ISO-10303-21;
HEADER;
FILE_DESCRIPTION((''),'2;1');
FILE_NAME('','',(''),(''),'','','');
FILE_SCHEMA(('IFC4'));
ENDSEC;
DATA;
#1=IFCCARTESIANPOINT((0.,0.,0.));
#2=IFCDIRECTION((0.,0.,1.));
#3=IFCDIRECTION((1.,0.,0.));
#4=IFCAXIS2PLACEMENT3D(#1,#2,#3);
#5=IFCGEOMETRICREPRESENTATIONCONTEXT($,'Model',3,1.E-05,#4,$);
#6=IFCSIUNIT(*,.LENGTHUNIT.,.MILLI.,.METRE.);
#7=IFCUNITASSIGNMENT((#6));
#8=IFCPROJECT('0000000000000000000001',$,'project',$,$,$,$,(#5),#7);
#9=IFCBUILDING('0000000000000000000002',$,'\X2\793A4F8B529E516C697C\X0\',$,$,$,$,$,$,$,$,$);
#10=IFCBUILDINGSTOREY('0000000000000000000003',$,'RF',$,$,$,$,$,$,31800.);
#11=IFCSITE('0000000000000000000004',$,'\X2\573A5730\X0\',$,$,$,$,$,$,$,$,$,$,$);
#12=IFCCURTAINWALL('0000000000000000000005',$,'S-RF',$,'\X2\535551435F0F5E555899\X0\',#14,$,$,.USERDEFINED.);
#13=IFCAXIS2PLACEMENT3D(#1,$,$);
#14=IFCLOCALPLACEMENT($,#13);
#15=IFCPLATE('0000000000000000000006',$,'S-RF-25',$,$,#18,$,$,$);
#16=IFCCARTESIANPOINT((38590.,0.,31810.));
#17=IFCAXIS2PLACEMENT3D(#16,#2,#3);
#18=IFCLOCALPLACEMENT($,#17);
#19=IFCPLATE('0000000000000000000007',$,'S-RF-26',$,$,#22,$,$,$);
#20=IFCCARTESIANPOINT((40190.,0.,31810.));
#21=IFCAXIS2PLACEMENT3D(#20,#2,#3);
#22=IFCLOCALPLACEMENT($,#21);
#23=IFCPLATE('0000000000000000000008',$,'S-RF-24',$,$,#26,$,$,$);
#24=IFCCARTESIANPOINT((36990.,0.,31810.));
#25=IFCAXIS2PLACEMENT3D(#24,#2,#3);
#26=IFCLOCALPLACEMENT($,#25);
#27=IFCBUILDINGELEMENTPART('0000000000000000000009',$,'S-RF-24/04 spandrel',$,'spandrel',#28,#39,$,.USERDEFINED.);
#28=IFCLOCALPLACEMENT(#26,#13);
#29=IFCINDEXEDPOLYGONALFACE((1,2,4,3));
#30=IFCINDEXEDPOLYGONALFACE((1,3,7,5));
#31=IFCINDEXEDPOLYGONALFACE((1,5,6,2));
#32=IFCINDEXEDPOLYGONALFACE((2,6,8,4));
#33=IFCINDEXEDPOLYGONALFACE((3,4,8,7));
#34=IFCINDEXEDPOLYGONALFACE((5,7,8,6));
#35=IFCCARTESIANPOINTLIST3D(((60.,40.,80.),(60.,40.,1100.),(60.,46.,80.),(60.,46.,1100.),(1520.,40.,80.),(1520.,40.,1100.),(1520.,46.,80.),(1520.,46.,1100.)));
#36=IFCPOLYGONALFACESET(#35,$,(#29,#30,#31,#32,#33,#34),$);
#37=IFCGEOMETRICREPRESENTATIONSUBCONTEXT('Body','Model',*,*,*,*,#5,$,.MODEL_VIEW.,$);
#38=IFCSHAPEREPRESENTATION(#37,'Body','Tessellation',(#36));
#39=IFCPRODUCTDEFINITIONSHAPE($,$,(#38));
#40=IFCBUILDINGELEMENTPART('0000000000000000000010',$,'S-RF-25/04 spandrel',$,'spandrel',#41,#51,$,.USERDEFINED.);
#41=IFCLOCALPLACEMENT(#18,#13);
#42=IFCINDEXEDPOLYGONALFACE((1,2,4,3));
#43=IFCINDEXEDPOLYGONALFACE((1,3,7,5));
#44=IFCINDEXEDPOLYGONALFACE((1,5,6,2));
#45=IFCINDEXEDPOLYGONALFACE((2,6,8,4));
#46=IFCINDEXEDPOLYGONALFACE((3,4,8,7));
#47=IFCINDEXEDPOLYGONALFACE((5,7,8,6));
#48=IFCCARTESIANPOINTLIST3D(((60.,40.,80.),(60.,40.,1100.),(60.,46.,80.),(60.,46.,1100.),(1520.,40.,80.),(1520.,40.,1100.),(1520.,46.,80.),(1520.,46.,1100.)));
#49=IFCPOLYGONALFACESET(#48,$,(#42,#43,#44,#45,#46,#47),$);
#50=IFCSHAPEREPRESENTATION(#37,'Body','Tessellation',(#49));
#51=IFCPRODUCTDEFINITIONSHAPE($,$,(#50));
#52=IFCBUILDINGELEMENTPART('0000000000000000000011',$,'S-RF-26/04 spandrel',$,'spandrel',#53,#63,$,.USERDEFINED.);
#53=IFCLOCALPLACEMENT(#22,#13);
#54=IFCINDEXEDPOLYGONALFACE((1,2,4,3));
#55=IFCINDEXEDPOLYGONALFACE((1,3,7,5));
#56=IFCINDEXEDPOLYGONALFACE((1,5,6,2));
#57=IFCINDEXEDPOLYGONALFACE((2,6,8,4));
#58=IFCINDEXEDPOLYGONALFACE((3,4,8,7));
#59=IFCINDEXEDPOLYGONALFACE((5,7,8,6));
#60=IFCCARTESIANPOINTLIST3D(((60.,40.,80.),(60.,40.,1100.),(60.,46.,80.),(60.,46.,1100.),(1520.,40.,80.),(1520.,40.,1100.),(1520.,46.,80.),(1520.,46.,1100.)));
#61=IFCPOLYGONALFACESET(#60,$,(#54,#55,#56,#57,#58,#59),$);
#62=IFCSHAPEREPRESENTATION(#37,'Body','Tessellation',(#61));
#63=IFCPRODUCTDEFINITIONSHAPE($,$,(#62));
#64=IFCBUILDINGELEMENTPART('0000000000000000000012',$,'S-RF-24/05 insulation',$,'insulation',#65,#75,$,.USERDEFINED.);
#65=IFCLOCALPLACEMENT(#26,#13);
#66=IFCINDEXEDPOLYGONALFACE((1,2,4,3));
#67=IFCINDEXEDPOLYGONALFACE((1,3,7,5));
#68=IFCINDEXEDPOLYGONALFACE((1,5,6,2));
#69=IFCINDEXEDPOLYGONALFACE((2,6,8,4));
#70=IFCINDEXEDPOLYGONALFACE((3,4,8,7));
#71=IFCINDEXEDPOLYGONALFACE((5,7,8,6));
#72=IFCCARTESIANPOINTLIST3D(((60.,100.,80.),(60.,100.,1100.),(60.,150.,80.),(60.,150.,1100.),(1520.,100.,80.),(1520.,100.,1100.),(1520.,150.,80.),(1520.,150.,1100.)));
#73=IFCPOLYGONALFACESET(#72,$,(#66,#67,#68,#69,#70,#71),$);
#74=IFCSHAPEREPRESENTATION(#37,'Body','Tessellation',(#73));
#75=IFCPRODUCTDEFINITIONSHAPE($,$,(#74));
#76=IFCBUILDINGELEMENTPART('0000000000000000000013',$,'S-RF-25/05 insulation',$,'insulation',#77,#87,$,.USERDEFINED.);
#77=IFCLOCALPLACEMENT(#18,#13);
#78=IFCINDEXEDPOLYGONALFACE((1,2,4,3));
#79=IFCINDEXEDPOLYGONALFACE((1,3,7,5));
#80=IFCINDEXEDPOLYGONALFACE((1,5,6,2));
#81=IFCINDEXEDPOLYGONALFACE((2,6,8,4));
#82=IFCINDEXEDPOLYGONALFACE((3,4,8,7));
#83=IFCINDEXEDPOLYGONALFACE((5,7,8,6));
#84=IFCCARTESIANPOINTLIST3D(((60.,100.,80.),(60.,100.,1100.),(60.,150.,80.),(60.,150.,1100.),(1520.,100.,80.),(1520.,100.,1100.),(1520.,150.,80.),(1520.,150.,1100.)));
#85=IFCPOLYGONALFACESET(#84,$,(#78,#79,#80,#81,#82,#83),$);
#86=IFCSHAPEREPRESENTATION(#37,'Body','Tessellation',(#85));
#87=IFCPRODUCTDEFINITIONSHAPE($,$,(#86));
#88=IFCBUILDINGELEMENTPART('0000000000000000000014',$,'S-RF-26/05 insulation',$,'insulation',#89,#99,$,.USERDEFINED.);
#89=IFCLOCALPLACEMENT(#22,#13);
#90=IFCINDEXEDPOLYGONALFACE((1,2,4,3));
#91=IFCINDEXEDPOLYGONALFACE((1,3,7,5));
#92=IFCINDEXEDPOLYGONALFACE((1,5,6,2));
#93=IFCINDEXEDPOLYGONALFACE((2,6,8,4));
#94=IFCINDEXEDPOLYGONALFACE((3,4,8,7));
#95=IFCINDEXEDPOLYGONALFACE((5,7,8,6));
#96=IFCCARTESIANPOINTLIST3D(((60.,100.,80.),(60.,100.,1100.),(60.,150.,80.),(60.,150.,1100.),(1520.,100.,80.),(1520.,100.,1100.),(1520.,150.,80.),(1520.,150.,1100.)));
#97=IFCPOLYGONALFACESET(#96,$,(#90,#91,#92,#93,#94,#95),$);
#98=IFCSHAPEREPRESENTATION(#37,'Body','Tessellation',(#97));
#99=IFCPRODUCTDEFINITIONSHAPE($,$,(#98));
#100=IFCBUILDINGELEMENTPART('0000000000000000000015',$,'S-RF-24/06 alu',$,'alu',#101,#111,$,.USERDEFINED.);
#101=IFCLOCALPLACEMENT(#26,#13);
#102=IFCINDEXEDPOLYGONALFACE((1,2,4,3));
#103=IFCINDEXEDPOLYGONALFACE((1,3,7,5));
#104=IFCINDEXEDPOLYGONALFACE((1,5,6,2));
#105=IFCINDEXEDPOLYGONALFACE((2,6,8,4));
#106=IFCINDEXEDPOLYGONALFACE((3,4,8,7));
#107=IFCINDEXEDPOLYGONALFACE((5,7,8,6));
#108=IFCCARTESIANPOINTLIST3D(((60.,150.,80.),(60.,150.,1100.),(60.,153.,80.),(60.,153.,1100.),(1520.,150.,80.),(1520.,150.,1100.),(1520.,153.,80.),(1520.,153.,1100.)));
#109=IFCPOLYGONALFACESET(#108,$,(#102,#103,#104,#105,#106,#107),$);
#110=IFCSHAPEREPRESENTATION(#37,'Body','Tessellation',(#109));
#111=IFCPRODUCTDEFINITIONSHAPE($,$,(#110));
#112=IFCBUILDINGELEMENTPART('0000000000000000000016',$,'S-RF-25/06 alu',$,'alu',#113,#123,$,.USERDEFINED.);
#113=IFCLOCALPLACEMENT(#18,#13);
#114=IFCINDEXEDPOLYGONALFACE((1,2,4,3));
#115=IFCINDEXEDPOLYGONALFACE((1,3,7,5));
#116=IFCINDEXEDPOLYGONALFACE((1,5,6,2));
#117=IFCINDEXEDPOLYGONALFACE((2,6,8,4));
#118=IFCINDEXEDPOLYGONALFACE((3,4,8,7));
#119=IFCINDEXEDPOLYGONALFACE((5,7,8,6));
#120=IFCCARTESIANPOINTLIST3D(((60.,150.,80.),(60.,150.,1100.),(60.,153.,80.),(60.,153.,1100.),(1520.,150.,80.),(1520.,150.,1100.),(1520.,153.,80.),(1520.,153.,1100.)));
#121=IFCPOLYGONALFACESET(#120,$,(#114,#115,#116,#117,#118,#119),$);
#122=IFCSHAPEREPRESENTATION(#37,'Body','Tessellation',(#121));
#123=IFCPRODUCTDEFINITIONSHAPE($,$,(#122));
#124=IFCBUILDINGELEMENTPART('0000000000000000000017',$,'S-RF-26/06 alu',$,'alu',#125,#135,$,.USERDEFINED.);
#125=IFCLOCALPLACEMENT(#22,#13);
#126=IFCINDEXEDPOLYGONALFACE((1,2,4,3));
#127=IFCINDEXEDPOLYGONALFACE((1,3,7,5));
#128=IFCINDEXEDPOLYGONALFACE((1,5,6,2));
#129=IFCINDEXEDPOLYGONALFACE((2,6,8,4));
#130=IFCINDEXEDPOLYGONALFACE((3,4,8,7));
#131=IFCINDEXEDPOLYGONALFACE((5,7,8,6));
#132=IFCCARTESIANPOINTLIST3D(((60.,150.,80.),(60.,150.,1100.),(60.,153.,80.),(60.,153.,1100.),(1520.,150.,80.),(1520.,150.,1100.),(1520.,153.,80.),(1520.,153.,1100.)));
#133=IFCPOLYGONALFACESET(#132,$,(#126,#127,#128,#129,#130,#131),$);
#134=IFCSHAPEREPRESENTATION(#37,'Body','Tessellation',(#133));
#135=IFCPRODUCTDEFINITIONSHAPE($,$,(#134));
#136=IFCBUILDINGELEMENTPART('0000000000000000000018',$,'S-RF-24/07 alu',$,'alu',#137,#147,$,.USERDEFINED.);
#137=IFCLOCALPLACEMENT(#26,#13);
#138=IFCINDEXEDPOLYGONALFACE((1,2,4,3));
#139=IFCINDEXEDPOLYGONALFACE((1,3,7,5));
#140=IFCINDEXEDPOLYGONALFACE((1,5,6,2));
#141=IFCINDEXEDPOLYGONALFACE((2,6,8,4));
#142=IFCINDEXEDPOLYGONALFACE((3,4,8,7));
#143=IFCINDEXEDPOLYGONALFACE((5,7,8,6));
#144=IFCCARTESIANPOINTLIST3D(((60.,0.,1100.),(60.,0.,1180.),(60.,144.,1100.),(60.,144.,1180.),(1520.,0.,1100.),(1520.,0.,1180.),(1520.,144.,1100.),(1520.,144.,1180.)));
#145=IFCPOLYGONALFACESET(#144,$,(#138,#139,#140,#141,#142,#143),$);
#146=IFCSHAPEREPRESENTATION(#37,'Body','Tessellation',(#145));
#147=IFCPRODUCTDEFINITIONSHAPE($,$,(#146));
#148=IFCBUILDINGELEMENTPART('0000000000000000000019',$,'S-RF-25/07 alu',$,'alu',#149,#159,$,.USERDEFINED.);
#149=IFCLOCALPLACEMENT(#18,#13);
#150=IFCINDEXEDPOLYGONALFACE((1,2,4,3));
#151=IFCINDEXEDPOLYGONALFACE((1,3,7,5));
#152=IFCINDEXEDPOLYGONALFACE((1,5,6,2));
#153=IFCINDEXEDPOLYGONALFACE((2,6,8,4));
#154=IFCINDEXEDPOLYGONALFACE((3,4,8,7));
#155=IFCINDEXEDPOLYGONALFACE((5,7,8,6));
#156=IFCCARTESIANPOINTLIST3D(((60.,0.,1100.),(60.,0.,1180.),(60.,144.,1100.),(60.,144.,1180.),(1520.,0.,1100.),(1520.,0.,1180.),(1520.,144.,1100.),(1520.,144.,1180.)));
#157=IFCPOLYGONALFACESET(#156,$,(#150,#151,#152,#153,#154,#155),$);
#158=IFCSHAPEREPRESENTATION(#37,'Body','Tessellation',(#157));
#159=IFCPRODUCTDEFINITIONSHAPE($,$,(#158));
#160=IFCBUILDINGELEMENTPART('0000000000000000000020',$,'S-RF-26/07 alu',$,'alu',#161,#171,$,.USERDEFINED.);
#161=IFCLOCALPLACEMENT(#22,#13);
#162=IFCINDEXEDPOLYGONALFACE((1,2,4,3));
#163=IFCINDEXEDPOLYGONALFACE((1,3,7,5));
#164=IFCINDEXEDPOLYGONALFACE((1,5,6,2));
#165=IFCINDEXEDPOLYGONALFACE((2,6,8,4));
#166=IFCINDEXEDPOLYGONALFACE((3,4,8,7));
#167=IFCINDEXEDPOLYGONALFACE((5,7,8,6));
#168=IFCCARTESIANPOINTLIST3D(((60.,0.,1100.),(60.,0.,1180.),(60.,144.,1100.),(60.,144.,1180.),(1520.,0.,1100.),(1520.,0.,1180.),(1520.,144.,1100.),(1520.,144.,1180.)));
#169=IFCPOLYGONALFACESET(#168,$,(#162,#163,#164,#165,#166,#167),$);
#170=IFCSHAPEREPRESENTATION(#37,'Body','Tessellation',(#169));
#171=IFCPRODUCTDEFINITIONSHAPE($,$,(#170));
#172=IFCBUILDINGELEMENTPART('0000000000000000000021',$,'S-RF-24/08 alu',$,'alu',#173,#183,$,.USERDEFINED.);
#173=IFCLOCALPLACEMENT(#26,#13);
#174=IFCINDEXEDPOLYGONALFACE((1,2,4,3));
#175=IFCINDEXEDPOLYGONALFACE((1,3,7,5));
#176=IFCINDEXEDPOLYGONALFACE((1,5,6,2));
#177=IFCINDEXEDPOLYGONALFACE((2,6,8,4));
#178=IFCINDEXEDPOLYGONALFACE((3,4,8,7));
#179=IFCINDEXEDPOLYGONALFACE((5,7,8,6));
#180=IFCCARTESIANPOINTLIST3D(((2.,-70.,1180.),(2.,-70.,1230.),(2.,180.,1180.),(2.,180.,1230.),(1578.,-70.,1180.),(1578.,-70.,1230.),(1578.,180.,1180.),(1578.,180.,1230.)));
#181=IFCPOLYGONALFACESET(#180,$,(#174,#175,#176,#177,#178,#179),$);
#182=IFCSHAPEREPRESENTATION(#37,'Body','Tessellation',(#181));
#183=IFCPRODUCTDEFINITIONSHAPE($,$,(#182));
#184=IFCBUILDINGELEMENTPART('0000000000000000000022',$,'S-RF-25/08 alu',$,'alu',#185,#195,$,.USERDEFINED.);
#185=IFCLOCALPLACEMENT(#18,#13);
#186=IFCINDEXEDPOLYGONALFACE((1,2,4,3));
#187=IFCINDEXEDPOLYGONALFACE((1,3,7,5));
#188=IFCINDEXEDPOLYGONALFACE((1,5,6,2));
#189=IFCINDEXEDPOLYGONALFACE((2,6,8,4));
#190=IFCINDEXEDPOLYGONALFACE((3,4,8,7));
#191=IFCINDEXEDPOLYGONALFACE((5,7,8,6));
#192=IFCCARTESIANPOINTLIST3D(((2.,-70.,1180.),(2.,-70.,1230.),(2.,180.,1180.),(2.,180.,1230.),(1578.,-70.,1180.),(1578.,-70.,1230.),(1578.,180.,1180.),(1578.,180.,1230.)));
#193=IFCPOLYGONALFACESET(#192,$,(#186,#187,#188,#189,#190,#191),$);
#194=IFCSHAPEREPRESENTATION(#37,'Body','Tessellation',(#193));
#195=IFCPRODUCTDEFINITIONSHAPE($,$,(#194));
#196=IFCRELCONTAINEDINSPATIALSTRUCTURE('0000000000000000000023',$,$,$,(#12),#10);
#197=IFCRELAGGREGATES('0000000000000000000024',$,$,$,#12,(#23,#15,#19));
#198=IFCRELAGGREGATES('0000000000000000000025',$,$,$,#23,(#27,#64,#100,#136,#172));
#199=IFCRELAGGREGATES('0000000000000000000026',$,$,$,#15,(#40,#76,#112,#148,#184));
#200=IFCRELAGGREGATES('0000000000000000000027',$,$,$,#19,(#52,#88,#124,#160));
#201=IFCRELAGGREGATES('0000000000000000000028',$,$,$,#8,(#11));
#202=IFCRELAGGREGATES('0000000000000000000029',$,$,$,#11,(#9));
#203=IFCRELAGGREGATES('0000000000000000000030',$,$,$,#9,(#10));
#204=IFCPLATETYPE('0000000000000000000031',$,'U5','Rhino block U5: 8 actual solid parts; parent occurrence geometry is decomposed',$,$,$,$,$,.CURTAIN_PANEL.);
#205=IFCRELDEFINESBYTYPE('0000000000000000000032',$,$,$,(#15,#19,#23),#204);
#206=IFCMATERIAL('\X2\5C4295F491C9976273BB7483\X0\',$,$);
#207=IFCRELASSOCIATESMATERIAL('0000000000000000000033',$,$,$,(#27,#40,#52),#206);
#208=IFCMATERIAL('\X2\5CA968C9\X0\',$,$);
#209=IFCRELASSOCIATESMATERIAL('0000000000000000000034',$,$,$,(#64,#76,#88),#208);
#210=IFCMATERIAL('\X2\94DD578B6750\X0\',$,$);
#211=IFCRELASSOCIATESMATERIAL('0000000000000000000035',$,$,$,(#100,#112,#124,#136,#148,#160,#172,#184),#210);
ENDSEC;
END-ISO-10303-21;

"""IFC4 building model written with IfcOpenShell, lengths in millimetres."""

from ifc_helpers import new_model, si_unit, frame, frame_2d, origin, origin_with_axes, place, context, subcontext, project, spatial, rectangle, extrude, source, transform, mapped, material, type_object, element, aggregate, save


model = new_model("IFC4")

# Units and contexts
model_context = context("Model", 3, precision=1e-05, world=origin_with_axes())
body_context = subcontext(model_context, "Body", "Model", "MODEL_VIEW")
ifc_project = project(units=[si_unit("LENGTHUNIT", "METRE", prefix="MILLI")], contexts=[model_context])

# Site, building, storey
site = spatial("IfcSite", under=ifc_project, Name="场地")
building = spatial("IfcBuilding", under=site, Name="示例办公楼")
storey = spatial("IfcBuildingStorey", under=building, Name="RF", Elevation=31800.0)

# Curtain wall, plates, building element parts
curtain_wall = element("IfcCurtainWall", 1, inside=storey, Name="S-RF", ObjectType="单元式幕墙", PredefinedType="USERDEFINED")
plate_type = type_object("IfcPlateType", Name="U5", Description="Rhino block U5: 8 actual solid parts; parent occurrence geometry is decomposed", PredefinedType="CURTAIN_PANEL")
plate_1_placement = place(None, frame((38590.0, 0.0, 31810.0), z_axis=(0.0, 0.0, 1.0), x_axis=(1.0, 0.0, 0.0)))
plate_1 = element("IfcPlate", 2, at=plate_1_placement, type_object=plate_type, Name="S-RF-25")
ifc_material_1 = material(Name="铝型材")
plate_2_placement = place(None, frame((40190.0, 0.0, 31810.0), z_axis=(0.0, 0.0, 1.0), x_axis=(1.0, 0.0, 0.0)))
plate_2 = element("IfcPlate", 3, at=plate_2_placement, type_object=plate_type, Name="S-RF-26")
plate_3_placement = place(None, frame((36990.0, 0.0, 31810.0), z_axis=(0.0, 0.0, 1.0), x_axis=(1.0, 0.0, 0.0)))
plate_3 = element("IfcPlate", 4, at=plate_3_placement, type_object=plate_type, Name="S-RF-24")
aggregate(curtain_wall, [plate_3, plate_1, plate_2])
ifc_material_2 = material(Name="层间釉面玻璃")
shared_shape_1 = source(origin(), body_context, "Body", "SweptSolid", [
    extrude(rectangle(XDim=1460.0, YDim=6.0, at=frame_2d((790.0, 43.0))), frame((0.0, 0.0, 80.0)), (0.0, 0.0, 1.0), 1020.0),
])
building_element_part_1_placement = place(plate_3_placement, origin())
building_element_part_1 = element("IfcBuildingElementPart", 5, at=building_element_part_1_placement, material=ifc_material_2, Name="S-RF-24/04 spandrel", ObjectType="spandrel", PredefinedType="USERDEFINED", context=body_context, shape_type="MappedRepresentation", body=[
    mapped(shared_shape_1, transform((0.0, 0.0, 0.0))),
])
building_element_part_2_placement = place(plate_1_placement, origin())
building_element_part_2 = element("IfcBuildingElementPart", 6, at=building_element_part_2_placement, material=ifc_material_2, Name="S-RF-25/04 spandrel", ObjectType="spandrel", PredefinedType="USERDEFINED", context=body_context, shape_type="MappedRepresentation", body=[
    mapped(shared_shape_1, transform((0.0, 0.0, 0.0))),
])
building_element_part_3_placement = place(plate_2_placement, origin())
building_element_part_3 = element("IfcBuildingElementPart", 7, at=building_element_part_3_placement, material=ifc_material_2, Name="S-RF-26/04 spandrel", ObjectType="spandrel", PredefinedType="USERDEFINED", context=body_context, shape_type="MappedRepresentation", body=[
    mapped(shared_shape_1, transform((0.0, 0.0, 0.0))),
])
ifc_material_3 = material(Name="岩棉")
shared_shape_2 = source(origin(), body_context, "Body", "SweptSolid", [
    extrude(rectangle(XDim=1460.0, YDim=50.0, at=frame_2d((790.0, 125.0))), frame((0.0, 0.0, 80.0)), (0.0, 0.0, 1.0), 1020.0),
])
building_element_part_4_placement = place(plate_3_placement, origin())
building_element_part_4 = element("IfcBuildingElementPart", 8, at=building_element_part_4_placement, material=ifc_material_3, Name="S-RF-24/05 insulation", ObjectType="insulation", PredefinedType="USERDEFINED", context=body_context, shape_type="MappedRepresentation", body=[
    mapped(shared_shape_2, transform((0.0, 0.0, 0.0))),
])
building_element_part_5_placement = place(plate_1_placement, origin())
building_element_part_5 = element("IfcBuildingElementPart", 9, at=building_element_part_5_placement, material=ifc_material_3, Name="S-RF-25/05 insulation", ObjectType="insulation", PredefinedType="USERDEFINED", context=body_context, shape_type="MappedRepresentation", body=[
    mapped(shared_shape_2, transform((0.0, 0.0, 0.0))),
])
building_element_part_6_placement = place(plate_2_placement, origin())
building_element_part_6 = element("IfcBuildingElementPart", 10, at=building_element_part_6_placement, material=ifc_material_3, Name="S-RF-26/05 insulation", ObjectType="insulation", PredefinedType="USERDEFINED", context=body_context, shape_type="MappedRepresentation", body=[
    mapped(shared_shape_2, transform((0.0, 0.0, 0.0))),
])
shared_shape_3 = source(origin(), body_context, "Body", "SweptSolid", [
    extrude(rectangle(XDim=1460.0, YDim=3.0, at=frame_2d((790.0, 151.5))), frame((0.0, 0.0, 80.0)), (0.0, 0.0, 1.0), 1020.0),
])
building_element_part_7_placement = place(plate_3_placement, origin())
building_element_part_7 = element("IfcBuildingElementPart", 11, at=building_element_part_7_placement, material=ifc_material_1, Name="S-RF-24/06 alu", ObjectType="alu", PredefinedType="USERDEFINED", context=body_context, shape_type="MappedRepresentation", body=[
    mapped(shared_shape_3, transform((0.0, 0.0, 0.0))),
])
building_element_part_8_placement = place(plate_1_placement, origin())
building_element_part_8 = element("IfcBuildingElementPart", 12, at=building_element_part_8_placement, material=ifc_material_1, Name="S-RF-25/06 alu", ObjectType="alu", PredefinedType="USERDEFINED", context=body_context, shape_type="MappedRepresentation", body=[
    mapped(shared_shape_3, transform((0.0, 0.0, 0.0))),
])
building_element_part_9_placement = place(plate_2_placement, origin())
building_element_part_9 = element("IfcBuildingElementPart", 13, at=building_element_part_9_placement, material=ifc_material_1, Name="S-RF-26/06 alu", ObjectType="alu", PredefinedType="USERDEFINED", context=body_context, shape_type="MappedRepresentation", body=[
    mapped(shared_shape_3, transform((0.0, 0.0, 0.0))),
])
shared_shape_4 = source(origin(), body_context, "Body", "SweptSolid", [
    extrude(rectangle(XDim=1460.0, YDim=144.0, at=frame_2d((790.0, 72.0))), frame((0.0, 0.0, 1100.0)), (0.0, 0.0, 1.0), 80.0),
])
building_element_part_10_placement = place(plate_3_placement, origin())
building_element_part_10 = element("IfcBuildingElementPart", 14, at=building_element_part_10_placement, material=ifc_material_1, Name="S-RF-24/07 alu", ObjectType="alu", PredefinedType="USERDEFINED", context=body_context, shape_type="MappedRepresentation", body=[
    mapped(shared_shape_4, transform((0.0, 0.0, 0.0))),
])
building_element_part_11_placement = place(plate_1_placement, origin())
building_element_part_11 = element("IfcBuildingElementPart", 15, at=building_element_part_11_placement, material=ifc_material_1, Name="S-RF-25/07 alu", ObjectType="alu", PredefinedType="USERDEFINED", context=body_context, shape_type="MappedRepresentation", body=[
    mapped(shared_shape_4, transform((0.0, 0.0, 0.0))),
])
building_element_part_12_placement = place(plate_2_placement, origin())
building_element_part_12 = element("IfcBuildingElementPart", 16, at=building_element_part_12_placement, material=ifc_material_1, Name="S-RF-26/07 alu", ObjectType="alu", PredefinedType="USERDEFINED", context=body_context, shape_type="MappedRepresentation", body=[
    mapped(shared_shape_4, transform((0.0, 0.0, 0.0))),
])
shared_shape_5 = source(origin(), body_context, "Body", "SweptSolid", [
    extrude(rectangle(XDim=1576.0, YDim=250.0, at=frame_2d((790.0, 55.0))), frame((0.0, 0.0, 1180.0)), (0.0, 0.0, 1.0), 50.0),
])
building_element_part_13_placement = place(plate_3_placement, origin())
building_element_part_13 = element("IfcBuildingElementPart", 17, at=building_element_part_13_placement, material=ifc_material_1, Name="S-RF-24/08 alu", ObjectType="alu", PredefinedType="USERDEFINED", context=body_context, shape_type="MappedRepresentation", body=[
    mapped(shared_shape_5, transform((0.0, 0.0, 0.0))),
])
aggregate(plate_3, [building_element_part_1, building_element_part_4, building_element_part_7, building_element_part_10, building_element_part_13])
building_element_part_14_placement = place(plate_1_placement, origin())
building_element_part_14 = element("IfcBuildingElementPart", 18, at=building_element_part_14_placement, material=ifc_material_1, Name="S-RF-25/08 alu", ObjectType="alu", PredefinedType="USERDEFINED", context=body_context, shape_type="MappedRepresentation", body=[
    mapped(shared_shape_5, transform((0.0, 0.0, 0.0))),
])
aggregate(plate_1, [building_element_part_2, building_element_part_5, building_element_part_8, building_element_part_11, building_element_part_14])
aggregate(plate_2, [building_element_part_3, building_element_part_6, building_element_part_9, building_element_part_12])

save(model, "model.ifc")
